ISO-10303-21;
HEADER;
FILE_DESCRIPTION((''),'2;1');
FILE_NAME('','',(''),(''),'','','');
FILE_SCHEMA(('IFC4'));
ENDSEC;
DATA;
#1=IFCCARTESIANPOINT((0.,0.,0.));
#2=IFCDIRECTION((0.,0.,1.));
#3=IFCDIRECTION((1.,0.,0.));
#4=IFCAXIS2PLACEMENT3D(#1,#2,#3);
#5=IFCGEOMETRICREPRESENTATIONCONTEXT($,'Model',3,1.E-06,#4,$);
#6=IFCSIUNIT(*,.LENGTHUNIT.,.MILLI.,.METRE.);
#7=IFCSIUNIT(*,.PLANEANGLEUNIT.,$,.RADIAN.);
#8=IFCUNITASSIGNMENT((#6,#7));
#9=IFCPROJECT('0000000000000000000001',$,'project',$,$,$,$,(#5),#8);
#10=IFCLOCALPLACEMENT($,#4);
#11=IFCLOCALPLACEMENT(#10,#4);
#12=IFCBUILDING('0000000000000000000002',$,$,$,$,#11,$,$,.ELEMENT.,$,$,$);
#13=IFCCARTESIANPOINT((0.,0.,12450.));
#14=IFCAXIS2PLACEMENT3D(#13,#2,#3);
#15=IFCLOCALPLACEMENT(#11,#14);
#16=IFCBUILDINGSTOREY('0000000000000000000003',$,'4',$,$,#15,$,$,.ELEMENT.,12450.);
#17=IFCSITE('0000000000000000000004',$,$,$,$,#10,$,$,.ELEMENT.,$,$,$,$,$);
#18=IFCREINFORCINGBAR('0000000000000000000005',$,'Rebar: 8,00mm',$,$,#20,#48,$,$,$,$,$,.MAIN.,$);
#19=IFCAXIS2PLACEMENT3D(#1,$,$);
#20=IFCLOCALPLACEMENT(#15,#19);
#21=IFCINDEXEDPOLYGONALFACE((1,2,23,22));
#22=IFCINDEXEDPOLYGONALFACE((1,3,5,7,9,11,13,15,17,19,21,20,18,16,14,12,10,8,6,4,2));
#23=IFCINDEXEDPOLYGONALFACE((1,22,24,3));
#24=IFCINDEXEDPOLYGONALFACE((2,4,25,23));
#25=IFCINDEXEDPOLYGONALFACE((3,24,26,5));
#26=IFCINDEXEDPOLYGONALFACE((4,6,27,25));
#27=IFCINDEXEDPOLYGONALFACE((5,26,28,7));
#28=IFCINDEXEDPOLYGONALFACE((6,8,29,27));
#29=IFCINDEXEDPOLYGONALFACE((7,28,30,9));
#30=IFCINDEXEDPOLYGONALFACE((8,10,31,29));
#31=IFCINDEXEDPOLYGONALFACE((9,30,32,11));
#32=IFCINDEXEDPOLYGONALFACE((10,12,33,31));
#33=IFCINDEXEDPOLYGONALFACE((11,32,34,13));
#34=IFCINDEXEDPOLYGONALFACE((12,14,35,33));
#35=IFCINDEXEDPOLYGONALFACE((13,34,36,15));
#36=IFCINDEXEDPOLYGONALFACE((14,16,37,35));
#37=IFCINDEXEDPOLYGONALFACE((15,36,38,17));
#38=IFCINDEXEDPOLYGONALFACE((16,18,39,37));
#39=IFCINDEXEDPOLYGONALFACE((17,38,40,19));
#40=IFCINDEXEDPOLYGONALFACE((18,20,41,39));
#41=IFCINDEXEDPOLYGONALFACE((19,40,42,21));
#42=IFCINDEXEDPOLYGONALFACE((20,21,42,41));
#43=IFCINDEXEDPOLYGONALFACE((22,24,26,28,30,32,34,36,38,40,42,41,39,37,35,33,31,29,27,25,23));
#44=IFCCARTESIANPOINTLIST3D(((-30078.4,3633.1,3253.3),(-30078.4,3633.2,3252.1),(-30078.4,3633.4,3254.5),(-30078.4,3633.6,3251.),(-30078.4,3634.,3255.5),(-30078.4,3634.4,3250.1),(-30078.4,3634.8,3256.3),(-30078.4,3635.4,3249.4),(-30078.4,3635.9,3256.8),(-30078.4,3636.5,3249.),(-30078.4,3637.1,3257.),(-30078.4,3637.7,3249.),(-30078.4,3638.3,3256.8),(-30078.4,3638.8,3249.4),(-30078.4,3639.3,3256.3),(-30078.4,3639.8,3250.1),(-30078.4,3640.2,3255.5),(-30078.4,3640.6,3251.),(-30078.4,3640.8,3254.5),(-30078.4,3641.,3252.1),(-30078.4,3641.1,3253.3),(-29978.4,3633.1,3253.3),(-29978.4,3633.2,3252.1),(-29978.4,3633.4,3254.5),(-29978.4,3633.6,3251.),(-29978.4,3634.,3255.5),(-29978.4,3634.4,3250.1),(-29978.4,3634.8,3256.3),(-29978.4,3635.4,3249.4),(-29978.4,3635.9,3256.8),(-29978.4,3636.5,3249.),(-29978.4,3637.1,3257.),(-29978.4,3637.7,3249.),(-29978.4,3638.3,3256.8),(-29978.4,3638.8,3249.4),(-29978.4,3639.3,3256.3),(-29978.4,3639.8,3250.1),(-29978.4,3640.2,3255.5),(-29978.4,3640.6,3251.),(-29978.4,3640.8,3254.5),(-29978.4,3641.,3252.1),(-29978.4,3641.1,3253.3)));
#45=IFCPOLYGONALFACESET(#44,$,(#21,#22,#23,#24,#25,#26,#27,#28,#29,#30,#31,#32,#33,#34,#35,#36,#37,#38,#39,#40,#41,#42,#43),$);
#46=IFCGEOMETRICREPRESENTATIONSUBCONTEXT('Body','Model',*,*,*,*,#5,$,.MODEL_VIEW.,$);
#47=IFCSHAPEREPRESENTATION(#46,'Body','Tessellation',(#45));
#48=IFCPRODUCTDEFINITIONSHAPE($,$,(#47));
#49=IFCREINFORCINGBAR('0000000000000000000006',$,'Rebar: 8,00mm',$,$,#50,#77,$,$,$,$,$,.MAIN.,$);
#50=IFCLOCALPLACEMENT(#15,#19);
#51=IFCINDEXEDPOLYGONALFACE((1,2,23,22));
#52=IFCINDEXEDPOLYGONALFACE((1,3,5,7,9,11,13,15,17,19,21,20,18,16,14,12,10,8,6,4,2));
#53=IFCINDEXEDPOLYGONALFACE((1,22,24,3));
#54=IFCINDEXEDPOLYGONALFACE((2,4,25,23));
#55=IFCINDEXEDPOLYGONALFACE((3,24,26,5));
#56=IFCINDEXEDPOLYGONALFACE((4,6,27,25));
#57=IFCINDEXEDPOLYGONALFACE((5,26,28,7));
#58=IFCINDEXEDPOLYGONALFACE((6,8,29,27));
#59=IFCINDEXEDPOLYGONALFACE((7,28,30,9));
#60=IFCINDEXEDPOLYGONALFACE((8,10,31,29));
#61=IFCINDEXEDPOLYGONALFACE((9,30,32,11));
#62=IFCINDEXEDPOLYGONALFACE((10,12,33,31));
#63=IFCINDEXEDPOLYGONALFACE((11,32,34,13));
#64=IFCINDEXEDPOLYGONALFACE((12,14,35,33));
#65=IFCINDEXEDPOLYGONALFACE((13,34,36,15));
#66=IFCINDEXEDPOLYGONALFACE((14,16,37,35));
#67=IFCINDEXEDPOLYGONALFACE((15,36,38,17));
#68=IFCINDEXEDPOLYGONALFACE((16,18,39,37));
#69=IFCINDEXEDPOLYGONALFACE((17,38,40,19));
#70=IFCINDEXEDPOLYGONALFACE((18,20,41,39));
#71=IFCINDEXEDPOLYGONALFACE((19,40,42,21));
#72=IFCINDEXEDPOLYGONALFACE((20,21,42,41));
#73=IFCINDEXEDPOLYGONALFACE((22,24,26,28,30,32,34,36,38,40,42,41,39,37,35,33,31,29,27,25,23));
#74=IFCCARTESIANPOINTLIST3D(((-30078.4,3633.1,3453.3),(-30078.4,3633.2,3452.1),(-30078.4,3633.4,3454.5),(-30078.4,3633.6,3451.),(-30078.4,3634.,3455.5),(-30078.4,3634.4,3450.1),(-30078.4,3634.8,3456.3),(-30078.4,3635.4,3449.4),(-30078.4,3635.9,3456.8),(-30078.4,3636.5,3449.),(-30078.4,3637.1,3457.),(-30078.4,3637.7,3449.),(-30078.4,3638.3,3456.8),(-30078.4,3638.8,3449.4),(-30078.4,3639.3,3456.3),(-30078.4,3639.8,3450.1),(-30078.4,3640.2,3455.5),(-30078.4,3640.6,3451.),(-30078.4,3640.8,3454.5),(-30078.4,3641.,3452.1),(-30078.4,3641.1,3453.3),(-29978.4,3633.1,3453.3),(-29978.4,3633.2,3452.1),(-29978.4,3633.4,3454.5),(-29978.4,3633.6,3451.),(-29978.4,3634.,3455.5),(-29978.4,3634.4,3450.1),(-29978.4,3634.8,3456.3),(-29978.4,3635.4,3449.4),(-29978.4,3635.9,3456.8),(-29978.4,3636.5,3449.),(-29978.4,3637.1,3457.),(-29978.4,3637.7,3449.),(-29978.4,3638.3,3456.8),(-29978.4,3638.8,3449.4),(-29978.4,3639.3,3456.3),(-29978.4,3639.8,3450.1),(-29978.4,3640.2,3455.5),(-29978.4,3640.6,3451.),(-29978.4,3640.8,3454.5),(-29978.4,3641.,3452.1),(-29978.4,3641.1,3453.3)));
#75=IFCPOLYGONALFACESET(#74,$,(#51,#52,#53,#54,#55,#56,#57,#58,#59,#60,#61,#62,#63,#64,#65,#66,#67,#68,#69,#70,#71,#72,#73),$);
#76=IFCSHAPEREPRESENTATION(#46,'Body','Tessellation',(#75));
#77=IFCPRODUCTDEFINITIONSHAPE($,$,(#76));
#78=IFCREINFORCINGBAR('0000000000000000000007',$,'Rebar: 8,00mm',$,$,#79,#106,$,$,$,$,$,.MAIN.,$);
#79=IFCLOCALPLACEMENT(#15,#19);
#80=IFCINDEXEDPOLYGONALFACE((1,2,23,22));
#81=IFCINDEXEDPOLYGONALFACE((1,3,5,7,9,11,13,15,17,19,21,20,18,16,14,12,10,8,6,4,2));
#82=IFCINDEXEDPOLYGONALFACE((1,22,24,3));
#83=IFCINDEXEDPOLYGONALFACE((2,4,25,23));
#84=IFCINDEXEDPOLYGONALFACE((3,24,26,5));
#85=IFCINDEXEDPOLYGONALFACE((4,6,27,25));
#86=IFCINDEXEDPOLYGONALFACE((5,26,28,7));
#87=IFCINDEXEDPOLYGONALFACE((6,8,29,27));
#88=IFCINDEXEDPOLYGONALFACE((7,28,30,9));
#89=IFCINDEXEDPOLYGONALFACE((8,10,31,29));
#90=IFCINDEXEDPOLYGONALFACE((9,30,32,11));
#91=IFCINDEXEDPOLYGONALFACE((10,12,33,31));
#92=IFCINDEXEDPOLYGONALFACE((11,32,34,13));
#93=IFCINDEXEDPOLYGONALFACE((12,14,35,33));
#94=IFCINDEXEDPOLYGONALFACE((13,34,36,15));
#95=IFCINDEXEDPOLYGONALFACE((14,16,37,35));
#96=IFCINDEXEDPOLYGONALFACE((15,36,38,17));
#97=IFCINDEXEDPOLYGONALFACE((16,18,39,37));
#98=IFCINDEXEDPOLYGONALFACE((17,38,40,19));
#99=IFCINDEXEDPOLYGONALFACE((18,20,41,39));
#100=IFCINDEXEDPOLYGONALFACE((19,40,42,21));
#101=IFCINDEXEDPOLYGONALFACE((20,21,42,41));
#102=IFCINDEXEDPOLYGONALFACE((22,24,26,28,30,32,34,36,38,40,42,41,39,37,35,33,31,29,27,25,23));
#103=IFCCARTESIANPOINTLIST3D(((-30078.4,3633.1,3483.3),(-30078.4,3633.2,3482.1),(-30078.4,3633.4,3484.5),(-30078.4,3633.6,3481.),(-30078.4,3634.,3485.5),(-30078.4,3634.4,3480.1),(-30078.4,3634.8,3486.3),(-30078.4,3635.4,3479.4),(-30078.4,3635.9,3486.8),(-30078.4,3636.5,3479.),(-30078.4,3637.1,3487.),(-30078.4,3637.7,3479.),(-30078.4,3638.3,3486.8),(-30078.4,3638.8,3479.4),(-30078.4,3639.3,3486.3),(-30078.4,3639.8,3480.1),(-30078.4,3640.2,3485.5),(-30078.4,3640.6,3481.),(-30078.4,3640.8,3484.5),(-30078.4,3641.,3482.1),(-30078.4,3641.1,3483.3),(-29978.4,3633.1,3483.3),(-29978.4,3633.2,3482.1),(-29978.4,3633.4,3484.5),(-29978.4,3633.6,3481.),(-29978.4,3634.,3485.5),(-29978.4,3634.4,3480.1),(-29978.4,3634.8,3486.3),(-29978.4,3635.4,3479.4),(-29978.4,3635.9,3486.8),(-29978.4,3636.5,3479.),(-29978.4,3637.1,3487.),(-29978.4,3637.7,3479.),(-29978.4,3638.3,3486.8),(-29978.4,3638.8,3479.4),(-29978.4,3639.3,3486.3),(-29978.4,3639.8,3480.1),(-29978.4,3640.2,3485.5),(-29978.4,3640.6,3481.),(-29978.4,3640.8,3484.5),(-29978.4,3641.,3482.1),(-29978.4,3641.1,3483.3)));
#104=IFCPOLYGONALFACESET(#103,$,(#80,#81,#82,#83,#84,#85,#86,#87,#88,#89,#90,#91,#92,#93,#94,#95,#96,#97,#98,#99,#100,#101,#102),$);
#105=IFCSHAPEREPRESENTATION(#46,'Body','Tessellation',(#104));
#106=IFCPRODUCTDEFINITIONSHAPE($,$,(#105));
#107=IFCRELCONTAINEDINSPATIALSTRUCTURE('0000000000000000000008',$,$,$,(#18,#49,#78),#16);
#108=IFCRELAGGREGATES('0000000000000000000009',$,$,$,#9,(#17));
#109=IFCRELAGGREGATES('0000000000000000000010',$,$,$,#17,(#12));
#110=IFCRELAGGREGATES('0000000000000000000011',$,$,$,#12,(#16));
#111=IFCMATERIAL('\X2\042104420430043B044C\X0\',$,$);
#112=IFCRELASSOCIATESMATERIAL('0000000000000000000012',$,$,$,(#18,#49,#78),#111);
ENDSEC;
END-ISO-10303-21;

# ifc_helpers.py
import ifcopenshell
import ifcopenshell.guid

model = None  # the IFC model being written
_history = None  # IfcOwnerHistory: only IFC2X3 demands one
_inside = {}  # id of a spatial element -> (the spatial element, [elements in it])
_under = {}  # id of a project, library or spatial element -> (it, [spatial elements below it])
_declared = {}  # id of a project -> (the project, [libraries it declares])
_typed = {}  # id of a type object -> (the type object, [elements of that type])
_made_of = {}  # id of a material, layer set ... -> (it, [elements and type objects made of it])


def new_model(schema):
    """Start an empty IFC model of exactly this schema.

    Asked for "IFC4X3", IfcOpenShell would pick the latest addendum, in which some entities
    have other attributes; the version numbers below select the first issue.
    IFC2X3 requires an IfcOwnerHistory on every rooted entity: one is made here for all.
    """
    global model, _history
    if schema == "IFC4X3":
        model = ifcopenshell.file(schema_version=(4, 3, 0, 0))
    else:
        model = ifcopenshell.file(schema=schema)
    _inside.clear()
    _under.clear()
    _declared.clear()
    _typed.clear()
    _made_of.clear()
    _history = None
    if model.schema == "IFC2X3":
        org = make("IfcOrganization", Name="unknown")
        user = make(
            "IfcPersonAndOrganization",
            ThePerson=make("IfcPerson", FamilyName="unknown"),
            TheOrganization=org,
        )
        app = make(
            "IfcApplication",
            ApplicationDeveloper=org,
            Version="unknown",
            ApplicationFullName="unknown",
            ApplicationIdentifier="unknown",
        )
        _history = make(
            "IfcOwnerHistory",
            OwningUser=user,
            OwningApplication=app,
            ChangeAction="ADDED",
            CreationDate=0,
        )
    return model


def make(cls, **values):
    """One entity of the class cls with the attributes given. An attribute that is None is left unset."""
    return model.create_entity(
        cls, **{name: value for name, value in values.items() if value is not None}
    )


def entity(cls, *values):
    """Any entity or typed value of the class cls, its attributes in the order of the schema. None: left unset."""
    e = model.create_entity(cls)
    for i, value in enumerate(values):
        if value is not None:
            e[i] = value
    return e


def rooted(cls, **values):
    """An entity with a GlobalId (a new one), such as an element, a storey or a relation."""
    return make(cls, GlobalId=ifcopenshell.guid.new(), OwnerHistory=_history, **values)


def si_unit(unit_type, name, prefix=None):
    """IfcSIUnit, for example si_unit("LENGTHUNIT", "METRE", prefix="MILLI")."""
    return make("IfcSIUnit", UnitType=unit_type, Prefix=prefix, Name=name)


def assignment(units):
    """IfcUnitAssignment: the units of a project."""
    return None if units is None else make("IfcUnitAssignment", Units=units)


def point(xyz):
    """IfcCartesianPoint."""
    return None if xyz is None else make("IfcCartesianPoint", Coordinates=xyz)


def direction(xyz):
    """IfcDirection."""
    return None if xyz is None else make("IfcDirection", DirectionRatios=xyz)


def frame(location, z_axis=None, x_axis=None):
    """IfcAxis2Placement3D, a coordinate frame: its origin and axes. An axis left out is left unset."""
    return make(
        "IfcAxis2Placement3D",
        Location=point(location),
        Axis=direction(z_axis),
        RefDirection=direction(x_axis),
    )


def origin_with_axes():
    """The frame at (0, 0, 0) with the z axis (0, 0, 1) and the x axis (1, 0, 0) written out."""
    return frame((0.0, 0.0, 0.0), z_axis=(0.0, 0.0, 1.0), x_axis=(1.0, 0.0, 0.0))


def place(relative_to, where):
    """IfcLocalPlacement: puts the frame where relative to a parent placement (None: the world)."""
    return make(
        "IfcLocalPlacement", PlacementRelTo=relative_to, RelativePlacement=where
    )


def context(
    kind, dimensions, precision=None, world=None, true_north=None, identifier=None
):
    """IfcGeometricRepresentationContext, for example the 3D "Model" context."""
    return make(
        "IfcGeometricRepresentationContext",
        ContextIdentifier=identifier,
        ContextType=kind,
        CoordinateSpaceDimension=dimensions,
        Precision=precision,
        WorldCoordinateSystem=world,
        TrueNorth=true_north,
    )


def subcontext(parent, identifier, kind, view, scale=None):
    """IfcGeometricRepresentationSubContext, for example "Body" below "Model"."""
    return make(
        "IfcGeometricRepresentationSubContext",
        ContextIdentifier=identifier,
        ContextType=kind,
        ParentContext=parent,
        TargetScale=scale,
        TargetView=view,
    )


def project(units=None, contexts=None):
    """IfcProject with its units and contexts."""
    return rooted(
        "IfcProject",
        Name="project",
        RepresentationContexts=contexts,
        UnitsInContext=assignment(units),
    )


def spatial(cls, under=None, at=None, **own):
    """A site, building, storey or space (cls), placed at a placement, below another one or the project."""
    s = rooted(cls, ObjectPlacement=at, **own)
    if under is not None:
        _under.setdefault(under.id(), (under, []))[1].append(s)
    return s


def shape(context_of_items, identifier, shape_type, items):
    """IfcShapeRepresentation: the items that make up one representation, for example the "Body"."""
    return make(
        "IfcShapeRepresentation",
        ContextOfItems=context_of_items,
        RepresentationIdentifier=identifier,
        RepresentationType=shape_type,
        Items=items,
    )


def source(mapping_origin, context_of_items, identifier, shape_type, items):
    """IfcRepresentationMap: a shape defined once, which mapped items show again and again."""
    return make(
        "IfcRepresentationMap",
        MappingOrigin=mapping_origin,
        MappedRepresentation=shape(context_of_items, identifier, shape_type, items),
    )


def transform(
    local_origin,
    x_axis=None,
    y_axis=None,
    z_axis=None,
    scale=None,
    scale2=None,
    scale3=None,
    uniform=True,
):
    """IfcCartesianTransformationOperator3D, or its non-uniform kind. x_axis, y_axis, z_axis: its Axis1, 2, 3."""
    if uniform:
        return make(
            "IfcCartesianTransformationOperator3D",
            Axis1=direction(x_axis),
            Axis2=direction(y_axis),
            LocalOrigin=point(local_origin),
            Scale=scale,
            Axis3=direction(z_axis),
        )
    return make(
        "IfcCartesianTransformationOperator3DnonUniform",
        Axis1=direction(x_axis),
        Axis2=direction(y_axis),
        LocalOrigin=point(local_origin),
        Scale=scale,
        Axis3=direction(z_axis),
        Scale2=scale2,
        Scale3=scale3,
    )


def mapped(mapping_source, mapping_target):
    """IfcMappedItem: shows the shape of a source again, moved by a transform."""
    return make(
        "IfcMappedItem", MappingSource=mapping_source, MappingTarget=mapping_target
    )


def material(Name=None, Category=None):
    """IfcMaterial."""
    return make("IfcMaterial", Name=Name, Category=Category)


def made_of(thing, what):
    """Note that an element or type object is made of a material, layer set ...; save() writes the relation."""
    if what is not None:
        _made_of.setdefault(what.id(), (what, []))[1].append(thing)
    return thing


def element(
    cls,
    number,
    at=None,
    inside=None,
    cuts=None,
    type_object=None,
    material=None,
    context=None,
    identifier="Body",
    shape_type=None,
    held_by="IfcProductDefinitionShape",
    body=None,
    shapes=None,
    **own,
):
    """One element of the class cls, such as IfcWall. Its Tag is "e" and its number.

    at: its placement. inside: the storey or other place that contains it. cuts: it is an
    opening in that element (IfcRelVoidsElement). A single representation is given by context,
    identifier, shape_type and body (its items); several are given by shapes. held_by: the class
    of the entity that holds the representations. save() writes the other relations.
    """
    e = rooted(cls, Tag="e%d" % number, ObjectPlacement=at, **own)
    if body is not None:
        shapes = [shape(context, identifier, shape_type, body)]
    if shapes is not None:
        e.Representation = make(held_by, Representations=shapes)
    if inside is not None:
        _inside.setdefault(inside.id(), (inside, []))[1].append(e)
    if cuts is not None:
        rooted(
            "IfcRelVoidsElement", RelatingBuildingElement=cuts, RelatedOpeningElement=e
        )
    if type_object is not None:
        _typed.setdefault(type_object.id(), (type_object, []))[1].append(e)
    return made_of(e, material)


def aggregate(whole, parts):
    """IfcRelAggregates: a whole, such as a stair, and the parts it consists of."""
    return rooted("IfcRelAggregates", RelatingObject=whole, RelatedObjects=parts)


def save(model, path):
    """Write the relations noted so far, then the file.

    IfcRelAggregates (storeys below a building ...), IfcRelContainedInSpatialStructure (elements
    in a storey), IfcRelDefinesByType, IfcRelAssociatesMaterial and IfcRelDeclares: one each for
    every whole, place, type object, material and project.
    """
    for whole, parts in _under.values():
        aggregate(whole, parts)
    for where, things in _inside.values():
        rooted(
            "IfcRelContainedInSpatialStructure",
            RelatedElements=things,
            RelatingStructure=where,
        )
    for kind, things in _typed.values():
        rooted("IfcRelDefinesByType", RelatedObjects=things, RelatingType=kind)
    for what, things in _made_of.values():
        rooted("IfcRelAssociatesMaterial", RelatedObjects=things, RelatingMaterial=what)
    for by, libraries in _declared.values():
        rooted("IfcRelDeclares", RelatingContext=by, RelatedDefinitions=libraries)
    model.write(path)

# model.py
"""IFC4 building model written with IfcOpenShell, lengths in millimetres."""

from ifc_helpers import new_model, entity, si_unit, frame, origin_with_axes, place, context, subcontext, project, spatial, source, transform, mapped, material, element, save


model = new_model("IFC4")

# Units and contexts
model_context = context("Model", 3, precision=1e-06, world=origin_with_axes())
body_context = subcontext(model_context, "Body", "Model", "MODEL_VIEW")
ifc_project = project(units=[si_unit("LENGTHUNIT", "METRE", prefix="MILLI"), si_unit("PLANEANGLEUNIT", "RADIAN")], contexts=[model_context])

# Site, building, storey
site_placement = place(None, origin_with_axes())
site = spatial("IfcSite", under=ifc_project, at=site_placement, CompositionType="ELEMENT")
building_placement = place(site_placement, origin_with_axes())
building = spatial("IfcBuilding", under=site, at=building_placement, CompositionType="ELEMENT")
storey_placement = place(building_placement, frame((0.0, 0.0, 12450.0), z_axis=(0.0, 0.0, 1.0), x_axis=(1.0, 0.0, 0.0)))
storey = spatial("IfcBuildingStorey", under=building, at=storey_placement, Name="4", CompositionType="ELEMENT", Elevation=12450.0)

# Reinforcing bars
ifc_material = material(Name="Сталь")
shared_shape_1 = source(origin_with_axes(), body_context, "Body", "AdvancedSweptSolid", [
    entity("IfcSweptDiskSolid", entity("IfcIndexedPolyCurve", entity("IfcCartesianPointList3D", [[0.0, 0.0, 0.0], [100.0, 0.0, 0.0]]), [entity("IfcLineIndex", [1, 2])]), 4.0),
])
reinforcing_bar_1_placement = place(storey_placement, origin_with_axes())
element("IfcReinforcingBar", 1, at=reinforcing_bar_1_placement, inside=storey, material=ifc_material, Name="Rebar: 8,00mm", PredefinedType="MAIN", context=body_context, shape_type="MappedRepresentation", body=[
    mapped(shared_shape_1, transform((-29978.4, 3637.1, 3253.0), x_axis=(-1.0, 0.0, 0.0), y_axis=(0.0, -1.0, 0.0), z_axis=(0.0, 0.0, 1.0), scale=1.0)),
])
reinforcing_bar_2_placement = place(storey_placement, origin_with_axes())
element("IfcReinforcingBar", 2, at=reinforcing_bar_2_placement, inside=storey, material=ifc_material, Name="Rebar: 8,00mm", PredefinedType="MAIN", context=body_context, shape_type="MappedRepresentation", body=[
    mapped(shared_shape_1, transform((-29978.4, 3637.1, 3453.0), x_axis=(-1.0, 0.0, 0.0), y_axis=(0.0, -1.0, 0.0), z_axis=(0.0, 0.0, 1.0), scale=1.0)),
])
reinforcing_bar_3_placement = place(storey_placement, origin_with_axes())
element("IfcReinforcingBar", 3, at=reinforcing_bar_3_placement, inside=storey, material=ifc_material, Name="Rebar: 8,00mm", PredefinedType="MAIN", context=body_context, shape_type="MappedRepresentation", body=[
    mapped(shared_shape_1, transform((-29978.4, 3637.1, 3483.0), x_axis=(-1.0, 0.0, 0.0), y_axis=(0.0, -1.0, 0.0), z_axis=(0.0, 0.0, 1.0), scale=1.0)),
])

save(model, "model.ifc")
